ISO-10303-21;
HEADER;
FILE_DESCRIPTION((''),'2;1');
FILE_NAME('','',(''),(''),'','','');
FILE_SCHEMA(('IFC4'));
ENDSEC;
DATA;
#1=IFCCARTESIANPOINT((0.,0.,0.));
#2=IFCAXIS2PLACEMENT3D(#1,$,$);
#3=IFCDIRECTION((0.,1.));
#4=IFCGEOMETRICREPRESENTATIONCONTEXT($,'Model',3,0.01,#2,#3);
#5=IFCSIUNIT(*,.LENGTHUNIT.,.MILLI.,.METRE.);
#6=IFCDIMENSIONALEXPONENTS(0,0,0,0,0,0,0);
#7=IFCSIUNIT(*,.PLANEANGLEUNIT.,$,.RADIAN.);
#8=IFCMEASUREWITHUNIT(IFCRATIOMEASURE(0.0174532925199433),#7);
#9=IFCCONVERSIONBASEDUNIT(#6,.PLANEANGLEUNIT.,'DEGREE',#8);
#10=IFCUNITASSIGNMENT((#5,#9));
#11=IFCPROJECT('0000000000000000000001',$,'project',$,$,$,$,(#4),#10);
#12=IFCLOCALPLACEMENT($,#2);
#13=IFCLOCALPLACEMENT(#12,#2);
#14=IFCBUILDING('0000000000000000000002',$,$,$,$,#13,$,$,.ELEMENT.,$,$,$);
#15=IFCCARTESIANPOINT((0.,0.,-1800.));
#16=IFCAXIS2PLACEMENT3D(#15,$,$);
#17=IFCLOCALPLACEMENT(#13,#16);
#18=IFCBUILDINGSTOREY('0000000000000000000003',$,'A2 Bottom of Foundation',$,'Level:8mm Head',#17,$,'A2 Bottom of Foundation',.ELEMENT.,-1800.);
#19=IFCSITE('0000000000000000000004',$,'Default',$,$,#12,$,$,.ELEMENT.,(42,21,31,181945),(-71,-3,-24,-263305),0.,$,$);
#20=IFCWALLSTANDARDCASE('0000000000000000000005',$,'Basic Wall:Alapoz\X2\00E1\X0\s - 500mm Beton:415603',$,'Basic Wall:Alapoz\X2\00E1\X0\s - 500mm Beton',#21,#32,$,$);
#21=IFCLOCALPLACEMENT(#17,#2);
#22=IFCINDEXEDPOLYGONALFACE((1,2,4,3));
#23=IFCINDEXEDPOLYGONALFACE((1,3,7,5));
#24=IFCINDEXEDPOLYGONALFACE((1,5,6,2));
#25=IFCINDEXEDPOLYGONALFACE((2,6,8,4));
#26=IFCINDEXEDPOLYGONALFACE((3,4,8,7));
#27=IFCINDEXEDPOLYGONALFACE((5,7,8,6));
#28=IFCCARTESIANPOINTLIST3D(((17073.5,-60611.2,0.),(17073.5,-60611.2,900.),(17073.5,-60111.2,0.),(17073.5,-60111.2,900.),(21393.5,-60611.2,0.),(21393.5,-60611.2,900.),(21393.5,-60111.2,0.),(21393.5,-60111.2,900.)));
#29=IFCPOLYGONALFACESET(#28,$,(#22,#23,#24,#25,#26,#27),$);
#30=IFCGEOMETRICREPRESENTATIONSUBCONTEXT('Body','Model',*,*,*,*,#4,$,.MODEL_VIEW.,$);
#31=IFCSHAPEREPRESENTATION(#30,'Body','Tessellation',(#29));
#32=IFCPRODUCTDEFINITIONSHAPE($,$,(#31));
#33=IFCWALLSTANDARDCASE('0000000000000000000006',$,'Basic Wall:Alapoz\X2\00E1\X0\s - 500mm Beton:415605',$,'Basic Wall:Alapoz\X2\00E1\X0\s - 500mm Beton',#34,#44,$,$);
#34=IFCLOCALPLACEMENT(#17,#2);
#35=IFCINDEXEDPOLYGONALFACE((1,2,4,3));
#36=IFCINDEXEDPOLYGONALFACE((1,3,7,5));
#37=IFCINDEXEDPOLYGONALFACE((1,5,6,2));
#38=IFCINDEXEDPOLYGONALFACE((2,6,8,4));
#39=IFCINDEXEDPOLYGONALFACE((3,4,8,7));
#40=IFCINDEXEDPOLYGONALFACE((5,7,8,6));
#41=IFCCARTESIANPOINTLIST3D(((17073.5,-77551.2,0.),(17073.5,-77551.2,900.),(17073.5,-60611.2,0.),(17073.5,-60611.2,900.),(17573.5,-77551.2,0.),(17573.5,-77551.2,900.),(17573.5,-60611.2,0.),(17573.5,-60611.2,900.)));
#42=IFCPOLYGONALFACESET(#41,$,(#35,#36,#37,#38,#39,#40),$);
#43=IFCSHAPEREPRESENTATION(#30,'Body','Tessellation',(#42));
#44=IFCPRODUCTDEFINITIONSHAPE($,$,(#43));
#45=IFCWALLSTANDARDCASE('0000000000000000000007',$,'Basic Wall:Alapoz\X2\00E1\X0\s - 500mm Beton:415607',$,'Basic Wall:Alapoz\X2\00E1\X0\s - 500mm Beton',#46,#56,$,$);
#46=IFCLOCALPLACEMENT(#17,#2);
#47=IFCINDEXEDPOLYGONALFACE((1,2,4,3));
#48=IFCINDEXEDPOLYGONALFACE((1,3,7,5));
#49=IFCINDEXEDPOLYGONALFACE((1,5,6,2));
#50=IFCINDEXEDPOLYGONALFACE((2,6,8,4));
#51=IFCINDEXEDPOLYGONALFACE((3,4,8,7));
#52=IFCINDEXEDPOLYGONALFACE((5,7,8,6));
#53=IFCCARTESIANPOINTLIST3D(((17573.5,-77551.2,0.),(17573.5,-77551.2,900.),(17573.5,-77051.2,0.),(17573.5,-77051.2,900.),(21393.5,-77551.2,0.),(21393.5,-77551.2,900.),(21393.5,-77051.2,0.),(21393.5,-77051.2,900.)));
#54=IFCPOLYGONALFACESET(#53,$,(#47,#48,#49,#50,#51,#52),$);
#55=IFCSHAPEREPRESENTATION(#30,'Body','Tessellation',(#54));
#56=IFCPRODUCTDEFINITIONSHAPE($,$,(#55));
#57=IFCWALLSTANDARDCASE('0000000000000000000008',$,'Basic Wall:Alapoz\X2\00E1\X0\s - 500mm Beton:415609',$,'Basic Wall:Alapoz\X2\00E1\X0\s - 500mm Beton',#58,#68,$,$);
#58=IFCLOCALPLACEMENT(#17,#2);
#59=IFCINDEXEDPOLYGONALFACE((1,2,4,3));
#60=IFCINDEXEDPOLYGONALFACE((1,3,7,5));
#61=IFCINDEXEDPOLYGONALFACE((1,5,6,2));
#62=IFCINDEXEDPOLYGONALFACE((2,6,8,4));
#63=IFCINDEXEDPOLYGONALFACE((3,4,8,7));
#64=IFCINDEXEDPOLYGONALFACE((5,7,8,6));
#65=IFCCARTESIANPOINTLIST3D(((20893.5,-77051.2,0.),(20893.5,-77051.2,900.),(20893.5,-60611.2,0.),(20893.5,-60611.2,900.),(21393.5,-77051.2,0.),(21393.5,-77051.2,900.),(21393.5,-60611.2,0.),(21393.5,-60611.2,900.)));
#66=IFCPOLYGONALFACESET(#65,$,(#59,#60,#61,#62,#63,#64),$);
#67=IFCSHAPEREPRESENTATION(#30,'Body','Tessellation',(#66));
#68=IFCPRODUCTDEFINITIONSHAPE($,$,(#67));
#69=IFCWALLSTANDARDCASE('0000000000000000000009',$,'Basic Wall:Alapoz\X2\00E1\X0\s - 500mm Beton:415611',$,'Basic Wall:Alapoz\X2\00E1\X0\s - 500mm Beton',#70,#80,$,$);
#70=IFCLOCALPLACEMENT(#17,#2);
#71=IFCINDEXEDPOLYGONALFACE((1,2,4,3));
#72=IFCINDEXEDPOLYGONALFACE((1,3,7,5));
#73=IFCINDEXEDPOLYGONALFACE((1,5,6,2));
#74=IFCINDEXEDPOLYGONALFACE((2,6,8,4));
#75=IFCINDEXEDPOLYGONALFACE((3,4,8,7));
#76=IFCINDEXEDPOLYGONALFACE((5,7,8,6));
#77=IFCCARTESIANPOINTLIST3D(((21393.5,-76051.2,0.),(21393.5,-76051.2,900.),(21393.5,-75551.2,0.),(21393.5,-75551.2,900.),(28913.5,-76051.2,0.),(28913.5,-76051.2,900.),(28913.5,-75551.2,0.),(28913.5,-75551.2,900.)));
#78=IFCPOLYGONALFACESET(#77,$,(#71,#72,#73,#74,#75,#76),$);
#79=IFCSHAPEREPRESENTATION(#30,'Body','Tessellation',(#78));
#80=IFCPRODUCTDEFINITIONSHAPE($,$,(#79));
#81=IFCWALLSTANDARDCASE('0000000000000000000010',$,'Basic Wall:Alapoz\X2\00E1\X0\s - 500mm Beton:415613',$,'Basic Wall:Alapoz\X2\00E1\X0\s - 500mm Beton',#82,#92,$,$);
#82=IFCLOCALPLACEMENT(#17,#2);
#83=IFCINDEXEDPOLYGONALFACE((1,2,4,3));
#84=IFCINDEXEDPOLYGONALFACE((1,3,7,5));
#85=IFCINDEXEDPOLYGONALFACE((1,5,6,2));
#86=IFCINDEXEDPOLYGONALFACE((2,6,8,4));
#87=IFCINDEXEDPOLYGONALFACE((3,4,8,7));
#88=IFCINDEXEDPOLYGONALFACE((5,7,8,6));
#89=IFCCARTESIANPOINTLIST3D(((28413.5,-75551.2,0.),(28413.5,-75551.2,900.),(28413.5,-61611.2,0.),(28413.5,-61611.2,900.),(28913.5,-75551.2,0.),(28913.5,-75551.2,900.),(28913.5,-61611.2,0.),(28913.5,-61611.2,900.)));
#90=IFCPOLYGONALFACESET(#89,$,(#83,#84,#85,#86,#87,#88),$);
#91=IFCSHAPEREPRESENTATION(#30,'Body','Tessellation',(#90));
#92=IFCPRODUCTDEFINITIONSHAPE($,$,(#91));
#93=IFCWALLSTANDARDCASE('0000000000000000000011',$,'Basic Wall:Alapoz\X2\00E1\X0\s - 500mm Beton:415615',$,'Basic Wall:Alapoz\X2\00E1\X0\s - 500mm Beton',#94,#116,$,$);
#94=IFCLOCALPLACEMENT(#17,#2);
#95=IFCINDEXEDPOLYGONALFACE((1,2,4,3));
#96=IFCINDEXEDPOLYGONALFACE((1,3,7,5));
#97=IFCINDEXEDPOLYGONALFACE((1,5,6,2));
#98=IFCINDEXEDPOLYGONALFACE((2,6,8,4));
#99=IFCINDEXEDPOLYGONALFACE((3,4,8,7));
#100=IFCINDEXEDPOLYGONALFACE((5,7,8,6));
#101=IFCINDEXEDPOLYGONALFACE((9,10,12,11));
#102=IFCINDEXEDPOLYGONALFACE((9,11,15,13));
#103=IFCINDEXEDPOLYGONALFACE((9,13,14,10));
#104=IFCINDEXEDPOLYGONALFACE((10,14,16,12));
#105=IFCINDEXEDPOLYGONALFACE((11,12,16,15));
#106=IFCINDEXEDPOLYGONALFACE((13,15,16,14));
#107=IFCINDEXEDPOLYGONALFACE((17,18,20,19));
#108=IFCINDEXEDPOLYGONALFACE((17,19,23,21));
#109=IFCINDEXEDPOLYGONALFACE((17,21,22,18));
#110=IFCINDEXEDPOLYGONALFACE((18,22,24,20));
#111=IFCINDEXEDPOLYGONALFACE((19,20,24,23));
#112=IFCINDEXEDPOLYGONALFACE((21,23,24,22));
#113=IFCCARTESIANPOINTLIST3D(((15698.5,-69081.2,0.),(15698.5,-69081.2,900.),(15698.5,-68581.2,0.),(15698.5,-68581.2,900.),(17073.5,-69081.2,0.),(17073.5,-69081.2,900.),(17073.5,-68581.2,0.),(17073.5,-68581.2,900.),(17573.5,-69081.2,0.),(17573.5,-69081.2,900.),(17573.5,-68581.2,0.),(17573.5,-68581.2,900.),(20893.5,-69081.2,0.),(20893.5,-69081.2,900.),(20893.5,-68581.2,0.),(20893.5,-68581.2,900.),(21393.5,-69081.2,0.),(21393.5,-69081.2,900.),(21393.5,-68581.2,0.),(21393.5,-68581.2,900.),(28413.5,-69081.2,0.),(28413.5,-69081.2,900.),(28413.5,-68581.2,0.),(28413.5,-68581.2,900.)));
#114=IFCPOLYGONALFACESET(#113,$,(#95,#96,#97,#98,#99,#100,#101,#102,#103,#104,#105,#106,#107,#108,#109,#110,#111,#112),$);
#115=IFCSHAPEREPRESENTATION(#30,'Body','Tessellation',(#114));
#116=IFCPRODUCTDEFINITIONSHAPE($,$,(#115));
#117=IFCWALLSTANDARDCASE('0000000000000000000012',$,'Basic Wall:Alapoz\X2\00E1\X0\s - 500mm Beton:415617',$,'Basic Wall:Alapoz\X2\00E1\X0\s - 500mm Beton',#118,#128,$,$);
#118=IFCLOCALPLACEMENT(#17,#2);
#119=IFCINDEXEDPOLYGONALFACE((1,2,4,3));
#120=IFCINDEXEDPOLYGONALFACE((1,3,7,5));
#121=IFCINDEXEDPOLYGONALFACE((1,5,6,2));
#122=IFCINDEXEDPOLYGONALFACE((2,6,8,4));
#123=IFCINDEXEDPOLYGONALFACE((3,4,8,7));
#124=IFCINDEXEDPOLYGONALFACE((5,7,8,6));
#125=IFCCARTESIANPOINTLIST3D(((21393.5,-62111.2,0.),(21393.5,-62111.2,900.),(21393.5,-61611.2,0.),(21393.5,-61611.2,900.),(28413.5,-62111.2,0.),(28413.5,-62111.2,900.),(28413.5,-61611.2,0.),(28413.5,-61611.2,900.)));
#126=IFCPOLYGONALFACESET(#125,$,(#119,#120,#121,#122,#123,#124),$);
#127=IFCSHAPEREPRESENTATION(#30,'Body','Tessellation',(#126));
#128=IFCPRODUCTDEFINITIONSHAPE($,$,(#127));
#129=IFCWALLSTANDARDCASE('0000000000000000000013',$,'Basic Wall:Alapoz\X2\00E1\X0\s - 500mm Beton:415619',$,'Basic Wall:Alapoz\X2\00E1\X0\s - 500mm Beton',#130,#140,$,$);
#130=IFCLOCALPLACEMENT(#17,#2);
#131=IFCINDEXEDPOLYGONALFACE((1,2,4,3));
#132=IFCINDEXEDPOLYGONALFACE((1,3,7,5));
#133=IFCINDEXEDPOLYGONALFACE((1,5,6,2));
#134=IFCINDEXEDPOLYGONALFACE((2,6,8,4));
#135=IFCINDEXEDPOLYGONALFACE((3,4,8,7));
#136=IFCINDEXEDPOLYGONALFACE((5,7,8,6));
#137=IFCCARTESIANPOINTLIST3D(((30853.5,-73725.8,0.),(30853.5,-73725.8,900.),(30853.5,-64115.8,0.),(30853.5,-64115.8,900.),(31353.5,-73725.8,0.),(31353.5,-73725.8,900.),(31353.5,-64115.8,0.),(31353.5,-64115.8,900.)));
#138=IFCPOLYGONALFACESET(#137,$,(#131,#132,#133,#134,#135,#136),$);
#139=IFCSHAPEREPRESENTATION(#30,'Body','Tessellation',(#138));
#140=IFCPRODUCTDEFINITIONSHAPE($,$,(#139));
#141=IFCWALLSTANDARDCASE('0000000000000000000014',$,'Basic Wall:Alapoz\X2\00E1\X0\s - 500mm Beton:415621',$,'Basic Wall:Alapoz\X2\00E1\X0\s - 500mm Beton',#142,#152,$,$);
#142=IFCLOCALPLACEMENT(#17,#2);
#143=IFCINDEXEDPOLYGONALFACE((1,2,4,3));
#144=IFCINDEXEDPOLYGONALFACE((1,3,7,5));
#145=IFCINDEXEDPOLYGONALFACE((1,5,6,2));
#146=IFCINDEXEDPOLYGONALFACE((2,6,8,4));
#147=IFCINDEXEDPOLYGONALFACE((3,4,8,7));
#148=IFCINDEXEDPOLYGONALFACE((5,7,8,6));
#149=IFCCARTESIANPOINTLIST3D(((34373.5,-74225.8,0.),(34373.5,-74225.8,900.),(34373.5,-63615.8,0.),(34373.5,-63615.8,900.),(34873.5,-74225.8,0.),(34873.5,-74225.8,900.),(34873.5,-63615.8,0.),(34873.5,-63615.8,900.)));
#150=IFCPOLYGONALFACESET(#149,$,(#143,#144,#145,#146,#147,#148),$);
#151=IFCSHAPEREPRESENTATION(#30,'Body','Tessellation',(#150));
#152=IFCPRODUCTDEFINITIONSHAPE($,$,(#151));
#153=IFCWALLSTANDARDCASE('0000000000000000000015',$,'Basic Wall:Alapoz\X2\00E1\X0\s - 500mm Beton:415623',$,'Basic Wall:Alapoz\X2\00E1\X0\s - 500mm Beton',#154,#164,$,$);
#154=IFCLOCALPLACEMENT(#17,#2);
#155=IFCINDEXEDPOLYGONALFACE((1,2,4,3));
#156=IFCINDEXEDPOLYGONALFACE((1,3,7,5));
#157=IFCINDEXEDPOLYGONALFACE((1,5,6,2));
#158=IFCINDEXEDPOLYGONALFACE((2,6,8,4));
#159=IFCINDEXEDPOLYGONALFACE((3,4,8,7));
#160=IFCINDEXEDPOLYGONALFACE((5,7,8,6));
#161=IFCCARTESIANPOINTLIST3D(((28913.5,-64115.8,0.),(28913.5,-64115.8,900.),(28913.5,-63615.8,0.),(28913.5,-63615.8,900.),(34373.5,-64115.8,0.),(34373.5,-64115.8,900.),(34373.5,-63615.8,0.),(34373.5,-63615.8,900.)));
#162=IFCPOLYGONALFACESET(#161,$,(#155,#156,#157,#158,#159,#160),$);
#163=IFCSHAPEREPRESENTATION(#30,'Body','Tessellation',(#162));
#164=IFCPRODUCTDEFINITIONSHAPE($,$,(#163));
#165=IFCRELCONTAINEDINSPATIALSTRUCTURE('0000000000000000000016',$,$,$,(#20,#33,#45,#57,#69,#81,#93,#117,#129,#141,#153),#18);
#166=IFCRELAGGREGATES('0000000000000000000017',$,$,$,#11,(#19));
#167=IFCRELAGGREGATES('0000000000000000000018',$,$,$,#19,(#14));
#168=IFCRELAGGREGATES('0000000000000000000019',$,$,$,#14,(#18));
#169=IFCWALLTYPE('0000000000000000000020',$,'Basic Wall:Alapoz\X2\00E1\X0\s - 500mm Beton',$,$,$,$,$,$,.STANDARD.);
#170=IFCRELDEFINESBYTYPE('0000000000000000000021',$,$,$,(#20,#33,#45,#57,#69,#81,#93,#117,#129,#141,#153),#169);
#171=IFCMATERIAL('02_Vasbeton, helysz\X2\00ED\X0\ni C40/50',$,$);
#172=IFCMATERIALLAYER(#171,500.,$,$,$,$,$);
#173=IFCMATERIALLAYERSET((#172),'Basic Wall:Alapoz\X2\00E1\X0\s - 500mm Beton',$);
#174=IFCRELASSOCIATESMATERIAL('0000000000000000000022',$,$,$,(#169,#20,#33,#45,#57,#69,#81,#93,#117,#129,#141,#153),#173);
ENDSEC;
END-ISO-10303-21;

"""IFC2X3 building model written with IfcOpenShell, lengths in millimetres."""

from ifc_helpers import new_model, entity, si_unit, converted_unit, direction, frame, frame_2d, origin, place, context, subcontext, project, spatial, rectangle, extrude, material, layer, layer_set, layer_usage, type_object, element, save


model = new_model("IFC2X3")

# Units and contexts
model_context = context("Model", 3, precision=0.01, world=origin(), true_north=direction((0.0, 1.0)))
body_context = subcontext(model_context, "Body", "Model", "MODEL_VIEW")
ifc_project = project(units=[si_unit("LENGTHUNIT", "METRE", prefix="MILLI"), converted_unit("PLANEANGLEUNIT", "DEGREE", entity("IfcRatioMeasure", 0.0174532925199433), si_unit("PLANEANGLEUNIT", "RADIAN"), dimensions=[0, 0, 0, 0, 0, 0, 0])], contexts=[model_context])

# Site, building, storey
site_placement = place(None, origin())
site = spatial("IfcSite", under=ifc_project, at=site_placement, Name="Default", CompositionType="ELEMENT", RefLatitude=(42, 21, 31, 181945), RefLongitude=(-71, -3, -24, -263305), RefElevation=0.0)
building_placement = place(site_placement, origin())
building = spatial("IfcBuilding", under=site, at=building_placement, CompositionType="ELEMENT")
storey_placement = place(building_placement, frame((0.0, 0.0, -1800.0)))
storey = spatial("IfcBuildingStorey", under=building, at=storey_placement, Name="A2 Bottom of Foundation", ObjectType="Level:8mm Head", LongName="A2 Bottom of Foundation", CompositionType="ELEMENT", Elevation=-1800.0)

# Walls
ifc_material = material(Name="02_Vasbeton, helyszíni C40/50")
ifc_layer = layer(ifc_material, 500.0)
ifc_layer_set = layer_set([ifc_layer], Name="Basic Wall:Alapozás - 500mm Beton")
ifc_layer_usage_1 = layer_usage(ifc_layer_set, "AXIS2", "NEGATIVE", 250.0)
wall_type = type_object("IfcWallType", Name="Basic Wall:Alapozás - 500mm Beton", PredefinedType="STANDARD", material=ifc_layer_set)
wall_1_placement = place(storey_placement, frame((21393.5, -60361.2, 0.0), z_axis=(0.0, 0.0, 1.0), x_axis=(-1.0, 0.0, 0.0)))
element("IfcWallStandardCase", 1, at=wall_1_placement, inside=storey, type_object=wall_type, material=ifc_layer_usage_1, Name="Basic Wall:Alapozás - 500mm Beton:415603", ObjectType="Basic Wall:Alapozás - 500mm Beton", context=body_context, shape_type="SweptSolid", body=[
    extrude(rectangle(XDim=4320.0, YDim=500.0, at=frame_2d((2160.0, 0.0), x_axis=(-1.0, 0.0))), origin(), (0.0, 0.0, 1.0), 900.0),
])
ifc_layer_usage_2 = layer_usage(ifc_layer_set, "AXIS2", "NEGATIVE", 250.0)
wall_2_placement = place(storey_placement, frame((17323.5, -60611.2, 0.0), z_axis=(0.0, 0.0, 1.0), x_axis=(0.0, -1.0, 0.0)))
element("IfcWallStandardCase", 2, at=wall_2_placement, inside=storey, type_object=wall_type, material=ifc_layer_usage_2, Name="Basic Wall:Alapozás - 500mm Beton:415605", ObjectType="Basic Wall:Alapozás - 500mm Beton", context=body_context, shape_type="SweptSolid", body=[
    extrude(rectangle(XDim=16940.0, YDim=500.0, at=frame_2d((8470.0, 0.0), x_axis=(-1.0, 0.0))), origin(), (0.0, 0.0, 1.0), 900.0),
])
ifc_layer_usage_3 = layer_usage(ifc_layer_set, "AXIS2", "NEGATIVE", 250.0)
wall_3_placement = place(storey_placement, frame((17573.5, -77301.2, 0.0)))
element("IfcWallStandardCase", 3, at=wall_3_placement, inside=storey, type_object=wall_type, material=ifc_layer_usage_3, Name="Basic Wall:Alapozás - 500mm Beton:415607", ObjectType="Basic Wall:Alapozás - 500mm Beton", context=body_context, shape_type="SweptSolid", body=[
    extrude(rectangle(XDim=3820.0, YDim=500.0, at=frame_2d((1910.0, 0.0), x_axis=(-1.0, 0.0))), origin(), (0.0, 0.0, 1.0), 900.0),
])
ifc_layer_usage_4 = layer_usage(ifc_layer_set, "AXIS2", "NEGATIVE", 250.0)
wall_4_placement = place(storey_placement, frame((21143.5, -77051.2, 0.0), z_axis=(0.0, 0.0, 1.0), x_axis=(0.0, 1.0, 0.0)))
element("IfcWallStandardCase", 4, at=wall_4_placement, inside=storey, type_object=wall_type, material=ifc_layer_usage_4, Name="Basic Wall:Alapozás - 500mm Beton:415609", ObjectType="Basic Wall:Alapozás - 500mm Beton", context=body_context, shape_type="SweptSolid", body=[
    extrude(rectangle(XDim=16440.0, YDim=500.0, at=frame_2d((8220.0, 0.0), x_axis=(-1.0, 0.0))), origin(), (0.0, 0.0, 1.0), 900.0),
])
ifc_layer_usage_5 = layer_usage(ifc_layer_set, "AXIS2", "NEGATIVE", 250.0)
wall_5_placement = place(storey_placement, frame((21393.5, -75801.2, 0.0)))
element("IfcWallStandardCase", 5, at=wall_5_placement, inside=storey, type_object=wall_type, material=ifc_layer_usage_5, Name="Basic Wall:Alapozás - 500mm Beton:415611", ObjectType="Basic Wall:Alapozás - 500mm Beton", context=body_context, shape_type="SweptSolid", body=[
    extrude(rectangle(XDim=7520.0, YDim=500.0, at=frame_2d((3760.0, 0.0), x_axis=(-1.0, 0.0))), origin(), (0.0, 0.0, 1.0), 900.0),
])
ifc_layer_usage_6 = layer_usage(ifc_layer_set, "AXIS2", "NEGATIVE", 250.0)
wall_6_placement = place(storey_placement, frame((28663.5, -75551.2, 0.0), z_axis=(0.0, 0.0, 1.0), x_axis=(0.0, 1.0, 0.0)))
element("IfcWallStandardCase", 6, at=wall_6_placement, inside=storey, type_object=wall_type, material=ifc_layer_usage_6, Name="Basic Wall:Alapozás - 500mm Beton:415613", ObjectType="Basic Wall:Alapozás - 500mm Beton", context=body_context, shape_type="SweptSolid", body=[
    extrude(rectangle(XDim=13940.0, YDim=500.0, at=frame_2d((6970.0, 0.0), x_axis=(-1.0, 0.0))), origin(), (0.0, 0.0, 1.0), 900.0),
])

# Wall, openings
ifc_layer_usage_7 = layer_usage(ifc_layer_set, "AXIS2", "NEGATIVE", 250.0)
wall_7_placement = place(storey_placement, frame((28413.5, -68831.2, 0.0), z_axis=(0.0, 0.0, 1.0), x_axis=(-1.0, 0.0, 0.0)))
wall_7 = element("IfcWallStandardCase", 7, at=wall_7_placement, inside=storey, type_object=wall_type, material=ifc_layer_usage_7, Name="Basic Wall:Alapozás - 500mm Beton:415615", ObjectType="Basic Wall:Alapozás - 500mm Beton", context=body_context, shape_type="SweptSolid", body=[
    extrude(rectangle(XDim=12715.0, YDim=500.0, at=frame_2d((6357.5, 0.0), x_axis=(-1.0, 0.0))), origin(), (0.0, 0.0, 1.0), 900.0),
])
opening_1_placement = place(storey_placement, frame((28413.5, -68831.2, 0.0), z_axis=(0.0, 0.0, 1.0), x_axis=(-1.0, 0.0, 0.0)))
element("IfcOpeningElement", 8, at=opening_1_placement, cuts=wall_7, ObjectType="Opening", context=body_context, shape_type="SweptSolid", body=[
    extrude(rectangle(XDim=900.0, YDim=500.0, at=frame_2d((0.0, 0.0), x_axis=(1.0, 0.0))), frame((7520.0, 0.0, 450.0), z_axis=(-1.0, 0.0, 0.0), x_axis=(0.0, 0.0, 1.0)), (0.0, 0.0, 1.0), 500.0),
])
opening_2_placement = place(storey_placement, frame((28413.5, -68831.2, 0.0), z_axis=(0.0, 0.0, 1.0), x_axis=(-1.0, 0.0, 0.0)))
element("IfcOpeningElement", 9, at=opening_2_placement, cuts=wall_7, ObjectType="Opening", context=body_context, shape_type="SweptSolid", body=[
    extrude(rectangle(XDim=900.0, YDim=500.0, at=frame_2d((0.0, 0.0), x_axis=(1.0, 0.0))), frame((11340.0, 0.0, 450.0), z_axis=(-1.0, 0.0, 0.0), x_axis=(0.0, 0.0, 1.0)), (0.0, 0.0, 1.0), 500.0),
])

# Walls
ifc_layer_usage_8 = layer_usage(ifc_layer_set, "AXIS2", "POSITIVE", -250.0)
wall_8_placement = place(storey_placement, frame((21393.5, -61861.2, 0.0)))
element("IfcWallStandardCase", 10, at=wall_8_placement, inside=storey, type_object=wall_type, material=ifc_layer_usage_8, Name="Basic Wall:Alapozás - 500mm Beton:415617", ObjectType="Basic Wall:Alapozás - 500mm Beton", context=body_context, shape_type="SweptSolid", body=[
    extrude(rectangle(XDim=7020.0, YDim=500.0, at=frame_2d((3510.0, 0.0), x_axis=(-1.0, 0.0))), origin(), (0.0, 0.0, 1.0), 900.0),
])
ifc_layer_usage_9 = layer_usage(ifc_layer_set, "AXIS2", "NEGATIVE", 250.0)
wall_9_placement = place(storey_placement, frame((31103.5, -73725.8, 0.0), z_axis=(0.0, 0.0, 1.0), x_axis=(0.0, 1.0, 0.0)))
element("IfcWallStandardCase", 11, at=wall_9_placement, inside=storey, type_object=wall_type, material=ifc_layer_usage_9, Name="Basic Wall:Alapozás - 500mm Beton:415619", ObjectType="Basic Wall:Alapozás - 500mm Beton", context=body_context, shape_type="SweptSolid", body=[
    extrude(rectangle(XDim=9610.0, YDim=500.0, at=frame_2d((4805.0, 0.0), x_axis=(-1.0, 0.0))), origin(), (0.0, 0.0, 1.0), 900.0),
])
ifc_layer_usage_10 = layer_usage(ifc_layer_set, "AXIS2", "NEGATIVE", 250.0)
wall_10_placement = place(storey_placement, frame((34623.5, -74225.8, 0.0), z_axis=(0.0, 0.0, 1.0), x_axis=(0.0, 1.0, 0.0)))
element("IfcWallStandardCase", 12, at=wall_10_placement, inside=storey, type_object=wall_type, material=ifc_layer_usage_10, Name="Basic Wall:Alapozás - 500mm Beton:415621", ObjectType="Basic Wall:Alapozás - 500mm Beton", context=body_context, shape_type="SweptSolid", body=[
    extrude(rectangle(XDim=10610.0, YDim=500.0, at=frame_2d((5305.0, 0.0), x_axis=(-1.0, 0.0))), origin(), (0.0, 0.0, 1.0), 900.0),
])
ifc_layer_usage_11 = layer_usage(ifc_layer_set, "AXIS2", "POSITIVE", -250.0)
wall_11_placement = place(storey_placement, frame((28913.5, -63865.8, 0.0)))
element("IfcWallStandardCase", 13, at=wall_11_placement, inside=storey, type_object=wall_type, material=ifc_layer_usage_11, Name="Basic Wall:Alapozás - 500mm Beton:415623", ObjectType="Basic Wall:Alapozás - 500mm Beton", context=body_context, shape_type="SweptSolid", body=[
    extrude(rectangle(XDim=5460.0, YDim=500.0, at=frame_2d((2730.0, 0.0), x_axis=(-1.0, 0.0))), origin(), (0.0, 0.0, 1.0), 900.0),
])

save(model, "model.ifc")
